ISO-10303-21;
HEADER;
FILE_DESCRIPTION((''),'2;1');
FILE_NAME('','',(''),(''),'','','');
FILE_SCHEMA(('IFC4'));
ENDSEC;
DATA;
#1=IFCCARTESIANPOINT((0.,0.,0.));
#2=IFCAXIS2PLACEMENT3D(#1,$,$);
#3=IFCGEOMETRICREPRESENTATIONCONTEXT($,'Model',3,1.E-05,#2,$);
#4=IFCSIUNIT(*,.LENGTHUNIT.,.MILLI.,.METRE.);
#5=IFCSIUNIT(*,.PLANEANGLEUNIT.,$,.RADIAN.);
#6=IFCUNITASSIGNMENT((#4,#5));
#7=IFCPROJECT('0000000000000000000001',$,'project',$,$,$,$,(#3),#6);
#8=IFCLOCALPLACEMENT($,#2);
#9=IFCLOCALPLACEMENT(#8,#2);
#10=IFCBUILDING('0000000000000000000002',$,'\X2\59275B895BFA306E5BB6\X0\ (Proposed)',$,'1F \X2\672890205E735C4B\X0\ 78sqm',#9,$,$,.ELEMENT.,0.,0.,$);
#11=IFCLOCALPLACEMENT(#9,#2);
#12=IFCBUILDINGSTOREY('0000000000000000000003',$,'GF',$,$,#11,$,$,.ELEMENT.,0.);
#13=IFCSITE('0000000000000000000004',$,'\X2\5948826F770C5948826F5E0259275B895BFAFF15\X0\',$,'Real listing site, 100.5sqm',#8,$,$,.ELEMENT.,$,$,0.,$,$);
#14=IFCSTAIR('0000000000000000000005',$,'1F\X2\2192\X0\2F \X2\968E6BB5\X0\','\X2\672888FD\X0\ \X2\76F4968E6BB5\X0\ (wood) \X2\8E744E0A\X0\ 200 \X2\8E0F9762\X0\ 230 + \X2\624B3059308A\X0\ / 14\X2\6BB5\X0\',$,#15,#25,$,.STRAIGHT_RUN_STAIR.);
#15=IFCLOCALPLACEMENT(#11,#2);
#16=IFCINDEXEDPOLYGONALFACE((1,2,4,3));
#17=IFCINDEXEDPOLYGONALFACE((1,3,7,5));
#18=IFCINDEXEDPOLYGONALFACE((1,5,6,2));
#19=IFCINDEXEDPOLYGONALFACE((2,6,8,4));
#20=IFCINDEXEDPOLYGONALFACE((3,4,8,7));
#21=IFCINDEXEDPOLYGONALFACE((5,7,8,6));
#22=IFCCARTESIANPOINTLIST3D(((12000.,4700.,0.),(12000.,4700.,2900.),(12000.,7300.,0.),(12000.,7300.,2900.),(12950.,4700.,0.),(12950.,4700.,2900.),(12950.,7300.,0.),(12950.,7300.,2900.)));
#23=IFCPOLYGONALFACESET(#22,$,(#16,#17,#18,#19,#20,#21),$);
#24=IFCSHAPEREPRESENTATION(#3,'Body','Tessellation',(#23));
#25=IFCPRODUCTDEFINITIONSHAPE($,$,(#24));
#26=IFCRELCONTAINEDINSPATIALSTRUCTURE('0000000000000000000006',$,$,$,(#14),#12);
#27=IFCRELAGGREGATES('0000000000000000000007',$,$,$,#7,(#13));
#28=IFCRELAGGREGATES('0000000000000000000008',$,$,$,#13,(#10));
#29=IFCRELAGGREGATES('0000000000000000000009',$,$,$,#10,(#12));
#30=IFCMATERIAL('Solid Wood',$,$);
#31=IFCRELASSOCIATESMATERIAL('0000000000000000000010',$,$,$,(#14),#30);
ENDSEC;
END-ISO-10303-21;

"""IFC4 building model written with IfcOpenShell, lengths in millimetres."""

from ifc_helpers import new_model, si_unit, frame, frame_2d, origin, place, context, project, spatial, rectangle, extrude, material, element, save


model = new_model("IFC4")

# Units and contexts
model_context = context("Model", 3, precision=1e-05, world=origin())
ifc_project = project(units=[si_unit("LENGTHUNIT", "METRE", prefix="MILLI"), si_unit("PLANEANGLEUNIT", "RADIAN")], contexts=[model_context])

# Site, building, storey
site_placement = place(None, origin())
site = spatial("IfcSite", under=ifc_project, at=site_placement, Name="奈良県奈良市大安寺５", ObjectType="Real listing site, 100.5sqm", CompositionType="ELEMENT", RefElevation=0.0)
building_placement = place(site_placement, origin())
building = spatial("IfcBuilding", under=site, at=building_placement, Name="大安寺の家 (Proposed)", ObjectType="1F 木造平屋 78sqm", CompositionType="ELEMENT", ElevationOfRefHeight=0.0, ElevationOfTerrain=0.0)
storey_placement = place(building_placement, origin())
storey = spatial("IfcBuildingStorey", under=building, at=storey_placement, Name="GF", CompositionType="ELEMENT", Elevation=0.0)

# Shared definitions
ifc_material_1 = material(Name="Solid Wood")

# Stair
stair_placement = place(storey_placement, frame((6000.0, 2350.0, 0.0)))
element("IfcStair", 1, at=stair_placement, inside=storey, material=ifc_material_1, Name="1F→2F 階段", Description="木製 直階段 (wood) 蹴上 200 踏面 230 + 手すり / 14段", PredefinedType="STRAIGHT_RUN_STAIR", context=model_context, shape_type="SweptSolid", body=[
    extrude(rectangle(XDim=950.0, YDim=2600.0, at=frame_2d((475.0, 1300.0))), frame((6000.0, 2350.0, 0.0)), (0.0, 0.0, 1.0), 2900.0),
])

save(model, "model.ifc")
